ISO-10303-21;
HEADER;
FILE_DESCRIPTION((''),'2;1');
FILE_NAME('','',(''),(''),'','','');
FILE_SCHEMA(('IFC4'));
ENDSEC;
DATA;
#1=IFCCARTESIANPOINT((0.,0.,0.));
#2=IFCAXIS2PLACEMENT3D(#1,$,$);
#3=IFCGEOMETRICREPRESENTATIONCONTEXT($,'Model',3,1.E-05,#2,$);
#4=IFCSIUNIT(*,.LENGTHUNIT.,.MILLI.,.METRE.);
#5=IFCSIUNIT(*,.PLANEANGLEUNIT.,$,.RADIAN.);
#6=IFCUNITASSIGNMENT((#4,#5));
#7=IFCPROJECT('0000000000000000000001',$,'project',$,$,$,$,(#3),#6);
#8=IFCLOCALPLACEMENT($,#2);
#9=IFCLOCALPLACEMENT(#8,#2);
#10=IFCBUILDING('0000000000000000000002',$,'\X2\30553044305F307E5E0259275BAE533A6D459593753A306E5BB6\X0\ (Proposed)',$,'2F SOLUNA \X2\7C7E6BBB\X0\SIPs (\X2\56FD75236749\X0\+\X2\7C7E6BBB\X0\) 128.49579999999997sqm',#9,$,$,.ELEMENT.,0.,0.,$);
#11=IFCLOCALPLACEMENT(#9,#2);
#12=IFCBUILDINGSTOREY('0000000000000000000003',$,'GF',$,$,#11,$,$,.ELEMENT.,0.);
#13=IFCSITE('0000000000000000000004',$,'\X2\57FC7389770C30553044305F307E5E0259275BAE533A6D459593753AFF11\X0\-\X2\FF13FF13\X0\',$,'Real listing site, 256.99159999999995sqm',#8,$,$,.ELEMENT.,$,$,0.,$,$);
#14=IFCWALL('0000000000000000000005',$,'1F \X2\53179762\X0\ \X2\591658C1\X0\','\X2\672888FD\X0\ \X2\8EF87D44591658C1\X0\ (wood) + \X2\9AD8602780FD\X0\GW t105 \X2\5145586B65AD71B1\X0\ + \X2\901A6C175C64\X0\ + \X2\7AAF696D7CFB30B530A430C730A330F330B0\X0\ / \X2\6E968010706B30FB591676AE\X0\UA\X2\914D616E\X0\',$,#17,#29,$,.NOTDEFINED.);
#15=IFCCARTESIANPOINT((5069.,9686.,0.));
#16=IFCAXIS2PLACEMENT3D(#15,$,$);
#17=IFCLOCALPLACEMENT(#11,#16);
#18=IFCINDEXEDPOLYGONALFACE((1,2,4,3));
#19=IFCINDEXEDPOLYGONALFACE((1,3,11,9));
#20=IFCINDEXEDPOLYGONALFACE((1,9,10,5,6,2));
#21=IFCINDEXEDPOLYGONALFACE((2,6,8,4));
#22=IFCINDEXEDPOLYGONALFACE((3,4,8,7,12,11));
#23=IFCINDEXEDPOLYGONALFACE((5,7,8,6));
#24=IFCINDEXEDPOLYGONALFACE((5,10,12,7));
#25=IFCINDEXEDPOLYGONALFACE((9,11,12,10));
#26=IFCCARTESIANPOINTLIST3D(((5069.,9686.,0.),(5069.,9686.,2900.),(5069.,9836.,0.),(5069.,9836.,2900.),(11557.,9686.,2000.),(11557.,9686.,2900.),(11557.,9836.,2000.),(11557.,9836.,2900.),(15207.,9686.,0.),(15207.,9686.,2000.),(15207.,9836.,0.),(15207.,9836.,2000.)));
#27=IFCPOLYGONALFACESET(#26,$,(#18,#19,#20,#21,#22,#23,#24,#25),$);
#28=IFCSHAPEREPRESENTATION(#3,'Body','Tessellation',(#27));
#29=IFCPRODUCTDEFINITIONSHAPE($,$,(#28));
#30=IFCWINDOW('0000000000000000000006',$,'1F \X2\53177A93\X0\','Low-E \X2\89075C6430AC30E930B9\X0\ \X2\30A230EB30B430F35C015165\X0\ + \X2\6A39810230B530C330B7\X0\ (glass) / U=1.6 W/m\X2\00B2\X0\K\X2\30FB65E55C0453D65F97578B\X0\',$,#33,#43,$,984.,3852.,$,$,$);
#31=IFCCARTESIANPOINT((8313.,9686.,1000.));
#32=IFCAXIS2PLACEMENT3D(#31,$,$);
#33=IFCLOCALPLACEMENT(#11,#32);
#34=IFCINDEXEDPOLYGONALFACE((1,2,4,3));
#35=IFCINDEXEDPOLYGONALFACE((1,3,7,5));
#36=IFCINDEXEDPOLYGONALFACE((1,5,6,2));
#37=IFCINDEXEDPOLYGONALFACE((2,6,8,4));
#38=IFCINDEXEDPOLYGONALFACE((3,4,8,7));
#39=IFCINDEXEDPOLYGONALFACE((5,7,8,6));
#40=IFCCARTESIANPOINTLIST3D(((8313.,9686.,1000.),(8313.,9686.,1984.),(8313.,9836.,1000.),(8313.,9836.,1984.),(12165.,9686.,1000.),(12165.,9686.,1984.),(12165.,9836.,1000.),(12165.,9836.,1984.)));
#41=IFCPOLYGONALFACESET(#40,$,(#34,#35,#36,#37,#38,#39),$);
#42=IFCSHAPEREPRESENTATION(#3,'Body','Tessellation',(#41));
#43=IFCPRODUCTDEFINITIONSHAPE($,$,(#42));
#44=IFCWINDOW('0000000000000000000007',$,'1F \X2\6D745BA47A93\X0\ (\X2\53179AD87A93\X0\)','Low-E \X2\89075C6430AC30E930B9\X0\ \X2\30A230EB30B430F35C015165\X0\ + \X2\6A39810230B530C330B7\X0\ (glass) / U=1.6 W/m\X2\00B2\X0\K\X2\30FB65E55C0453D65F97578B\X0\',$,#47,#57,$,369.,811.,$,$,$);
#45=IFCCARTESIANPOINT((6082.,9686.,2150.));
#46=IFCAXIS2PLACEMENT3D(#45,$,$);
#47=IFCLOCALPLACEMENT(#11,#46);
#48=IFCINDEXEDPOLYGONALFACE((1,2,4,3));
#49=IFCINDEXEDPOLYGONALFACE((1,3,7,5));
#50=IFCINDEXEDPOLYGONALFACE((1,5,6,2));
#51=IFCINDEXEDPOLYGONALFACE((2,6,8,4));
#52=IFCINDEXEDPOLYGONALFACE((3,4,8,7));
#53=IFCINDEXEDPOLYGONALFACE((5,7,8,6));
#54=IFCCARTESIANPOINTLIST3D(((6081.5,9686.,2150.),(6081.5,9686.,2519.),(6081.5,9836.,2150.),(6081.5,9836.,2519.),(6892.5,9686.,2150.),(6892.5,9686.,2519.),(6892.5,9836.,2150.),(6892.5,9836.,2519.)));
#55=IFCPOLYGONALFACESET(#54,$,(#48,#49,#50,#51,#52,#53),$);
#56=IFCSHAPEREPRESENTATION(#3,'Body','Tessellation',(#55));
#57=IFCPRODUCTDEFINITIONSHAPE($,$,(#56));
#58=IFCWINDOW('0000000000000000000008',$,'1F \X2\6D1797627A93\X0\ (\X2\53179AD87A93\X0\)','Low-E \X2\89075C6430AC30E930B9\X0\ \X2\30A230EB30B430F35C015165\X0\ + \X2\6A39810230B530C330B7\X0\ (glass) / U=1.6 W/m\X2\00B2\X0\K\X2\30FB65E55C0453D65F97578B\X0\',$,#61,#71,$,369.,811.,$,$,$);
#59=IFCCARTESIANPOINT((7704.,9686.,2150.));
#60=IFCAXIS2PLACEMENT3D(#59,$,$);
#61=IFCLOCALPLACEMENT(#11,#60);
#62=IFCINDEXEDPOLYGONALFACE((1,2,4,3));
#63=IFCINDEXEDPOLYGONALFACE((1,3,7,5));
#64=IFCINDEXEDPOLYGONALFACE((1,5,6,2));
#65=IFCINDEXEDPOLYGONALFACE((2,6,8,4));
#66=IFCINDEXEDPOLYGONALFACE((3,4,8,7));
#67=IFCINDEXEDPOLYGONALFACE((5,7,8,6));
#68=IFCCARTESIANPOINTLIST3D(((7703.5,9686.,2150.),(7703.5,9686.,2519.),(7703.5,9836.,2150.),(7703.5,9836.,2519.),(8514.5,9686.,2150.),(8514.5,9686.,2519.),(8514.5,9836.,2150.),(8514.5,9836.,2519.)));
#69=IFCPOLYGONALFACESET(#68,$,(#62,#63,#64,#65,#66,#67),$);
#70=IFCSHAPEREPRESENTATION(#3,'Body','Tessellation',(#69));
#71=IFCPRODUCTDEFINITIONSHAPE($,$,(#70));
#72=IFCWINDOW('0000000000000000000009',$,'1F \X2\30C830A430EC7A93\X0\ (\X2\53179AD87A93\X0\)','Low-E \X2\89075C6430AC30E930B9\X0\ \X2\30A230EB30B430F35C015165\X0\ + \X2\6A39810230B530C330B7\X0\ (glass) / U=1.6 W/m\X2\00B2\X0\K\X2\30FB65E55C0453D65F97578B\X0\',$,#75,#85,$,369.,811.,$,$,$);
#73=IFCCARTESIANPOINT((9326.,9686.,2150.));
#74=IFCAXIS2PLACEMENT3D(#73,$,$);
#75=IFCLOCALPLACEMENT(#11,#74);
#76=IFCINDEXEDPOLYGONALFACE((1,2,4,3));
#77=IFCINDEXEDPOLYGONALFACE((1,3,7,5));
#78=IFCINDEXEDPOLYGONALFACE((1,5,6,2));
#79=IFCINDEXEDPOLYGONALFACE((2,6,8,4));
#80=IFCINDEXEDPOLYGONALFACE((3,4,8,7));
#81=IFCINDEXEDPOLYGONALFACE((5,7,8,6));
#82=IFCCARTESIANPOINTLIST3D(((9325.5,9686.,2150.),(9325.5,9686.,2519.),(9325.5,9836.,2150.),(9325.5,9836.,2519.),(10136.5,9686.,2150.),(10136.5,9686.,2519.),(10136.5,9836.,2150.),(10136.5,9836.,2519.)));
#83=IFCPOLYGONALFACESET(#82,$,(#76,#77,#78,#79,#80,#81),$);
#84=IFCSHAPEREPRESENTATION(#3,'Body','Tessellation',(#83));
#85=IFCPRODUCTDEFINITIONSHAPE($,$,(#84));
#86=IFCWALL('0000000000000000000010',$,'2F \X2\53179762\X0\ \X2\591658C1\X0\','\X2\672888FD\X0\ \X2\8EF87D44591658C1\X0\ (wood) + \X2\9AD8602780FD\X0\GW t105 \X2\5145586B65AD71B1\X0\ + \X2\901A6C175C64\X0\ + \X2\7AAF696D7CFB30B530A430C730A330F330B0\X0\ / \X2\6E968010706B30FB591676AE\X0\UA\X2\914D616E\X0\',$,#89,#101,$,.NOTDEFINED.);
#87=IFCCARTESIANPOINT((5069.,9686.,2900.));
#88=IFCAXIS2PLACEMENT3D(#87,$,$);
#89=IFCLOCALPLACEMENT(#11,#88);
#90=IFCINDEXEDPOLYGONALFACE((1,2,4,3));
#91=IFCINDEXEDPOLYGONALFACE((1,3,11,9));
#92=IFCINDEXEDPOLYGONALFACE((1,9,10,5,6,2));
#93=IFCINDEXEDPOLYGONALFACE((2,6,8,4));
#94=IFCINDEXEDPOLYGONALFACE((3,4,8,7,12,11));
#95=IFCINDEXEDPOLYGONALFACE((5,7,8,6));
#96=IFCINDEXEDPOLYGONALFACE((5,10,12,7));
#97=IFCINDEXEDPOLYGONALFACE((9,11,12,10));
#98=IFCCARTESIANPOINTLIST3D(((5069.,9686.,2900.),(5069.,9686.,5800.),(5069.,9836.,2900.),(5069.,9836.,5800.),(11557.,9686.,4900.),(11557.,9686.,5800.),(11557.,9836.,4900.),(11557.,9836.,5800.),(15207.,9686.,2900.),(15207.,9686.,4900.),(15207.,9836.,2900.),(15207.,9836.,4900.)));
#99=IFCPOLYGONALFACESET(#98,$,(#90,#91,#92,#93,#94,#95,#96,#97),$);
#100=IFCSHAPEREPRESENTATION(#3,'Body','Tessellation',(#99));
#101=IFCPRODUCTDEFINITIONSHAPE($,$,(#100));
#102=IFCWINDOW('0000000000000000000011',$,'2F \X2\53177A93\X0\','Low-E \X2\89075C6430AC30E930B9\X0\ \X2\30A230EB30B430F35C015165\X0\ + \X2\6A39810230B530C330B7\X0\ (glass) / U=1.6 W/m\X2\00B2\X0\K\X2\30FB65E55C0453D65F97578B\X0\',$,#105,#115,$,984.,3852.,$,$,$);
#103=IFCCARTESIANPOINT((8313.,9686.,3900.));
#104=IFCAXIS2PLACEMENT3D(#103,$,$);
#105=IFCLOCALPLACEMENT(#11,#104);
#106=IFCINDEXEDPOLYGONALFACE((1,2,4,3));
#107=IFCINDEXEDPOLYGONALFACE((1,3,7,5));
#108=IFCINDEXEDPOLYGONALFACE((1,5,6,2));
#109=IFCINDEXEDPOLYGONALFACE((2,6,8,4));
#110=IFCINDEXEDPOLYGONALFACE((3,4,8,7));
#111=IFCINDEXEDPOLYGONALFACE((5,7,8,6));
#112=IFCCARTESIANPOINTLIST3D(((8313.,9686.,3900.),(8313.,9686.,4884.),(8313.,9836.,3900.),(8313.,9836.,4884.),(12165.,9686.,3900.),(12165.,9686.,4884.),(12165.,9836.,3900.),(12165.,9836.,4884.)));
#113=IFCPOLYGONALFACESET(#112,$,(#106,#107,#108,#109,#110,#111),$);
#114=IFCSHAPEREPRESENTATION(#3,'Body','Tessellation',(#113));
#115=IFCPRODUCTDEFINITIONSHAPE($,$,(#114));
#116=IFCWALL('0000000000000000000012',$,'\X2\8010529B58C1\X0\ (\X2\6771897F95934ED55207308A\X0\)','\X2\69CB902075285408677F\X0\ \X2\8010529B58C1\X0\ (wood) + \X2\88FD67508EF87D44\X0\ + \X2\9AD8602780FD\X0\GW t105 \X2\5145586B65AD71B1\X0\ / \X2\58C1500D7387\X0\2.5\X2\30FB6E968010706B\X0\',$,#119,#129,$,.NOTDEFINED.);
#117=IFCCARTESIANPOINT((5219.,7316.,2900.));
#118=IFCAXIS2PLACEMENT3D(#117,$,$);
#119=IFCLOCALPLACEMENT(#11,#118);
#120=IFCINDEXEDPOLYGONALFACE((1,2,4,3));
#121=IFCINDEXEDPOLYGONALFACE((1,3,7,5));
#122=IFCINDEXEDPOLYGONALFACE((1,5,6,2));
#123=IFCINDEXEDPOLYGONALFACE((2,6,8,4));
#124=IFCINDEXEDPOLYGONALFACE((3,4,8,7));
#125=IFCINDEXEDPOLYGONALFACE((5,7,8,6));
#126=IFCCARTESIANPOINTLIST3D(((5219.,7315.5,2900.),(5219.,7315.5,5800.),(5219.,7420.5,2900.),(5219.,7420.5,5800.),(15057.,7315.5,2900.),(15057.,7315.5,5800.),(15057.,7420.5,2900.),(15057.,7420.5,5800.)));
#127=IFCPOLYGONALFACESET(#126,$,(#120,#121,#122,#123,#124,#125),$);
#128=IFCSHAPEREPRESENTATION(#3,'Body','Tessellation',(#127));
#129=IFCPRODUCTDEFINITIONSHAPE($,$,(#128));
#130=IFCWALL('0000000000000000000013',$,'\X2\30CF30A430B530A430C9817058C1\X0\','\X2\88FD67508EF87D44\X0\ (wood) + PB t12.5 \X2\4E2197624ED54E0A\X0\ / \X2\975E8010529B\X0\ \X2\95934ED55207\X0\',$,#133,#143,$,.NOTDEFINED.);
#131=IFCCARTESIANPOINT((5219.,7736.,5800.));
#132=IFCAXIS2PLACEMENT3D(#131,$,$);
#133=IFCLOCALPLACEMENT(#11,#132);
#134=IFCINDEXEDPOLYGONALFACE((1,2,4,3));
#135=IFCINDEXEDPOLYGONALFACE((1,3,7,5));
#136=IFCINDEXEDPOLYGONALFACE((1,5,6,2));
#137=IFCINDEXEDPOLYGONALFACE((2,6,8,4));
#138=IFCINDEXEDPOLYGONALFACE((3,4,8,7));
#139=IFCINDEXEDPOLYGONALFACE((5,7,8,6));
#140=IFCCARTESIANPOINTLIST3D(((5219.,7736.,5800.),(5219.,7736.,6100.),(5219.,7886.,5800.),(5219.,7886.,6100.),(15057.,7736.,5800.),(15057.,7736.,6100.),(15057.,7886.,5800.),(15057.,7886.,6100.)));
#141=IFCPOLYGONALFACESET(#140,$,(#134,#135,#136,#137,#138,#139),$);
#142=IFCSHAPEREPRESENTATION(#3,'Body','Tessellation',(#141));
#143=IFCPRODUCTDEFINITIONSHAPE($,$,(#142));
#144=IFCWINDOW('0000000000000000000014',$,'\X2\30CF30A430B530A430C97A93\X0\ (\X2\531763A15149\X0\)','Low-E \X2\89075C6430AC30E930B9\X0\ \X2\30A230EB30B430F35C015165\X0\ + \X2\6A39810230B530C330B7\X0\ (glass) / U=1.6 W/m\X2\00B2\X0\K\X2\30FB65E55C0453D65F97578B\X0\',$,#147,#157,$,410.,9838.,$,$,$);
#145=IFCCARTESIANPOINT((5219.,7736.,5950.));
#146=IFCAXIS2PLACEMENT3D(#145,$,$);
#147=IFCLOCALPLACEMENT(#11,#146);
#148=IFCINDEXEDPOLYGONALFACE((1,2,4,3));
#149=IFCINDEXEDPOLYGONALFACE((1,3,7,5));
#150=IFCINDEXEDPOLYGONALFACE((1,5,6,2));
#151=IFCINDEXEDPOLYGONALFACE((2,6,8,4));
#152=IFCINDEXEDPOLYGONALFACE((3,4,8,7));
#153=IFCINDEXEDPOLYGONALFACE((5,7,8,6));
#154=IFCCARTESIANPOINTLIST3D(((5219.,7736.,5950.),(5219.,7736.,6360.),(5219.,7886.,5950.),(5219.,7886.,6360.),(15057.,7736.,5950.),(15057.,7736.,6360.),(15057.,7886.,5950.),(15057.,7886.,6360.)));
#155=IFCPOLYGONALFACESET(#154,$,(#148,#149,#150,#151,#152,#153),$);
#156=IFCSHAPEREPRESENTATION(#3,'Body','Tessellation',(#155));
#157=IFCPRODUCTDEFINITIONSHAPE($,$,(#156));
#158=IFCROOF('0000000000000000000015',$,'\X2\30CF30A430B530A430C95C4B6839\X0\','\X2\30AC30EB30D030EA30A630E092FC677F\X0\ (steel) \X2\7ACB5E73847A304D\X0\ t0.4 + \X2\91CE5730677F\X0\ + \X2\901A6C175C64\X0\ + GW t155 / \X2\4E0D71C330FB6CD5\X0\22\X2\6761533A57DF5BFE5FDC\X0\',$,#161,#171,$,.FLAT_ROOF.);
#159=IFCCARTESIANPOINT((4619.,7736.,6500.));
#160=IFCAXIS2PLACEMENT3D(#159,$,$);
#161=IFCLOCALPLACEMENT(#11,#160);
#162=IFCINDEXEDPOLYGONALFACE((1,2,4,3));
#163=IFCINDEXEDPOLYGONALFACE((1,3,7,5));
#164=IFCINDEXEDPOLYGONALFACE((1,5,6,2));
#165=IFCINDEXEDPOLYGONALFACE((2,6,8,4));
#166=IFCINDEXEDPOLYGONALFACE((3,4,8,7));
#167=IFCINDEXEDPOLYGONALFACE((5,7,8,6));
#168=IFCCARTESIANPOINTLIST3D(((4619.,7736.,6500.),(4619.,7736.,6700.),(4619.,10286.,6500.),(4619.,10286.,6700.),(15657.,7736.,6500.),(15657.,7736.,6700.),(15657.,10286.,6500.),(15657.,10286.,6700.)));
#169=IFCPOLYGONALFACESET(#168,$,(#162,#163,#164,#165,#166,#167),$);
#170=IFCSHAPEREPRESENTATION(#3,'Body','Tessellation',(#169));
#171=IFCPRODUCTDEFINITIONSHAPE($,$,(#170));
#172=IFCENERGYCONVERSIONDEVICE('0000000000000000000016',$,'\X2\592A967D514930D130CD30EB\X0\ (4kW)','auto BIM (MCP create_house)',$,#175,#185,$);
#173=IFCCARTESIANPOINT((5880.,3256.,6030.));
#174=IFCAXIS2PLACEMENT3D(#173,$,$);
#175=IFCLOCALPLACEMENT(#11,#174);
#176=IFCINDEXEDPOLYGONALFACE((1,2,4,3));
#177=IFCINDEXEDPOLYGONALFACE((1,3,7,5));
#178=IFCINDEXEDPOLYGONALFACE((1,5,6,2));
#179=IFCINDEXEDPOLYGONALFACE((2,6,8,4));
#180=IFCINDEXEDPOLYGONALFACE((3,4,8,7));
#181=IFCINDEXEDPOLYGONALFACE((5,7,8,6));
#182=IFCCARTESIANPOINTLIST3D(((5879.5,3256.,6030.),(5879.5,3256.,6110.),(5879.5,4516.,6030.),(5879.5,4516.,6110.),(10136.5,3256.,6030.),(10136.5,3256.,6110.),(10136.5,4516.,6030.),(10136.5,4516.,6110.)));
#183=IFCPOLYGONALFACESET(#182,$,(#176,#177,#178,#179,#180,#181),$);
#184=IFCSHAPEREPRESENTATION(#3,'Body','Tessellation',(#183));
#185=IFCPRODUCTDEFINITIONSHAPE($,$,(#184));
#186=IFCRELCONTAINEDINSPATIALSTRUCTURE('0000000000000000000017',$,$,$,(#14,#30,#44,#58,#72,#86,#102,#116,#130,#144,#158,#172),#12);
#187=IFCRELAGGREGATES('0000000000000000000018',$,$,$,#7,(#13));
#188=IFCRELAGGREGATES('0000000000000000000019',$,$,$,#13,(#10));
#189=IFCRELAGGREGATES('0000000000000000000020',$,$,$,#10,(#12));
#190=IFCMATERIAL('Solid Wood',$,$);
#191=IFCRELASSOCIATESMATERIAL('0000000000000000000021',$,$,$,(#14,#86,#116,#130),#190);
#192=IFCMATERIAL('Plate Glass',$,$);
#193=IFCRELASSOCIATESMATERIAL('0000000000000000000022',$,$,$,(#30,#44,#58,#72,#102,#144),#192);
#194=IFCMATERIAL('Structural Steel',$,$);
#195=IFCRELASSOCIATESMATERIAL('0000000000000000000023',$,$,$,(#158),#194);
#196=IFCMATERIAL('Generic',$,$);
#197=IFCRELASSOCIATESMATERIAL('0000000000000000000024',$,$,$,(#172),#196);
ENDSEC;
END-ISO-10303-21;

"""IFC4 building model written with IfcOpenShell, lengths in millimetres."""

from ifc_helpers import new_model, si_unit, frame, frame_2d, origin, place, context, project, spatial, rectangle, extrude, material, element, fill, save


model = new_model("IFC4")

# Units and contexts
model_context = context("Model", 3, precision=1e-05, world=origin())
ifc_project = project(units=[si_unit("LENGTHUNIT", "METRE", prefix="MILLI"), si_unit("PLANEANGLEUNIT", "RADIAN")], contexts=[model_context])

# Site, building, storey
site_placement = place(None, origin())
site = spatial("IfcSite", under=ifc_project, at=site_placement, Name="埼玉県さいたま市大宮区浅間町１-３３", ObjectType="Real listing site, 256.99159999999995sqm", CompositionType="ELEMENT", RefElevation=0.0)
building_placement = place(site_placement, origin())
building = spatial("IfcBuilding", under=site, at=building_placement, Name="さいたま市大宮区浅間町の家 (Proposed)", ObjectType="2F SOLUNA 籾殻SIPs (国産杉+籾殻) 128.49579999999997sqm", CompositionType="ELEMENT", ElevationOfRefHeight=0.0, ElevationOfTerrain=0.0)
storey_placement = place(building_placement, origin())
storey = spatial("IfcBuildingStorey", under=building, at=storey_placement, Name="GF", CompositionType="ELEMENT", Elevation=0.0)

# Wall, openings, windows
ifc_material_1 = material(Name="Solid Wood")
wall_1_placement = place(storey_placement, frame((5069.0, 9686.0, 0.0)))
wall_1 = element("IfcWall", 1, at=wall_1_placement, inside=storey, material=ifc_material_1, Name="1F 北面 外壁", Description="木製 軸組外壁 (wood) + 高性能GW t105 充填断熱 + 通気層 + 窯業系サイディング / 準耐火・外皮UA配慮", PredefinedType="NOTDEFINED", context=model_context, shape_type="SweptSolid", body=[
    extrude(rectangle(XDim=10138.0, YDim=150.0, at=frame_2d((5069.0, 75.0))), frame((5069.0, 9686.0, 0.0)), (0.0, 0.0, 1.0), 2900.0),
])
opening_1_placement = place(storey_placement, frame((8313.0, 9686.0, 1000.0)))
opening_1 = element("IfcOpeningElement", 2, at=opening_1_placement, cuts=wall_1, PredefinedType="NOTDEFINED", context=model_context, shape_type="SweptSolid", body=[
    extrude(rectangle(XDim=3852.0, YDim=150.0, at=frame_2d((1926.0, 75.0))), frame((8313.0, 9686.0, 1000.0)), (0.0, 0.0, 1.0), 984.0),
])
opening_2_placement = place(storey_placement, frame((6082.0, 9686.0, 2150.0)))
opening_2 = element("IfcOpeningElement", 3, at=opening_2_placement, cuts=wall_1, PredefinedType="NOTDEFINED", context=model_context, shape_type="SweptSolid", body=[
    extrude(rectangle(XDim=811.0, YDim=150.0, at=frame_2d((405.0, 75.0))), frame((6082.0, 9686.0, 2150.0)), (0.0, 0.0, 1.0), 369.0),
])
opening_3_placement = place(storey_placement, frame((7704.0, 9686.0, 2150.0)))
opening_3 = element("IfcOpeningElement", 4, at=opening_3_placement, cuts=wall_1, PredefinedType="NOTDEFINED", context=model_context, shape_type="SweptSolid", body=[
    extrude(rectangle(XDim=811.0, YDim=150.0, at=frame_2d((405.0, 75.0))), frame((7704.0, 9686.0, 2150.0)), (0.0, 0.0, 1.0), 369.0),
])
opening_4_placement = place(storey_placement, frame((9326.0, 9686.0, 2150.0)))
opening_4 = element("IfcOpeningElement", 5, at=opening_4_placement, cuts=wall_1, PredefinedType="NOTDEFINED", context=model_context, shape_type="SweptSolid", body=[
    extrude(rectangle(XDim=811.0, YDim=150.0, at=frame_2d((405.0, 75.0))), frame((9326.0, 9686.0, 2150.0)), (0.0, 0.0, 1.0), 369.0),
])
ifc_material_2 = material(Name="Plate Glass")
window_1_placement = place(storey_placement, frame((8313.0, 9686.0, 1000.0)))
window_1 = element("IfcWindow", 6, at=window_1_placement, inside=storey, material=ifc_material_2, Name="1F 北窓", Description="Low-E 複層ガラス アルゴン封入 + 樹脂サッシ (glass) / U=1.6 W/m²K・日射取得型", OverallHeight=984.0, OverallWidth=3852.0, context=model_context, shape_type="SweptSolid", body=[
    extrude(rectangle(XDim=3852.0, YDim=150.0, at=frame_2d((1926.0, 75.0))), frame((8313.0, 9686.0, 1000.0)), (0.0, 0.0, 1.0), 984.0),
])
fill(opening_1, window_1)
window_2_placement = place(storey_placement, frame((6082.0, 9686.0, 2150.0)))
window_2 = element("IfcWindow", 7, at=window_2_placement, inside=storey, material=ifc_material_2, Name="1F 浴室窓 (北高窓)", Description="Low-E 複層ガラス アルゴン封入 + 樹脂サッシ (glass) / U=1.6 W/m²K・日射取得型", OverallHeight=369.0, OverallWidth=811.0, context=model_context, shape_type="SweptSolid", body=[
    extrude(rectangle(XDim=811.0, YDim=150.0, at=frame_2d((405.0, 75.0))), frame((6082.0, 9686.0, 2150.0)), (0.0, 0.0, 1.0), 369.0),
])
fill(opening_2, window_2)
window_3_placement = place(storey_placement, frame((7704.0, 9686.0, 2150.0)))
window_3 = element("IfcWindow", 8, at=window_3_placement, inside=storey, material=ifc_material_2, Name="1F 洗面窓 (北高窓)", Description="Low-E 複層ガラス アルゴン封入 + 樹脂サッシ (glass) / U=1.6 W/m²K・日射取得型", OverallHeight=369.0, OverallWidth=811.0, context=model_context, shape_type="SweptSolid", body=[
    extrude(rectangle(XDim=811.0, YDim=150.0, at=frame_2d((405.0, 75.0))), frame((7704.0, 9686.0, 2150.0)), (0.0, 0.0, 1.0), 369.0),
])
fill(opening_3, window_3)
window_4_placement = place(storey_placement, frame((9326.0, 9686.0, 2150.0)))
window_4 = element("IfcWindow", 9, at=window_4_placement, inside=storey, material=ifc_material_2, Name="1F トイレ窓 (北高窓)", Description="Low-E 複層ガラス アルゴン封入 + 樹脂サッシ (glass) / U=1.6 W/m²K・日射取得型", OverallHeight=369.0, OverallWidth=811.0, context=model_context, shape_type="SweptSolid", body=[
    extrude(rectangle(XDim=811.0, YDim=150.0, at=frame_2d((405.0, 75.0))), frame((9326.0, 9686.0, 2150.0)), (0.0, 0.0, 1.0), 369.0),
])
fill(opening_4, window_4)

# Wall, opening, window
wall_2_placement = place(storey_placement, frame((5069.0, 9686.0, 2900.0)))
wall_2 = element("IfcWall", 10, at=wall_2_placement, inside=storey, material=ifc_material_1, Name="2F 北面 外壁", Description="木製 軸組外壁 (wood) + 高性能GW t105 充填断熱 + 通気層 + 窯業系サイディング / 準耐火・外皮UA配慮", PredefinedType="NOTDEFINED", context=model_context, shape_type="SweptSolid", body=[
    extrude(rectangle(XDim=10138.0, YDim=150.0, at=frame_2d((5069.0, 75.0))), frame((5069.0, 9686.0, 2900.0)), (0.0, 0.0, 1.0), 2900.0),
])
opening_5_placement = place(storey_placement, frame((8313.0, 9686.0, 3900.0)))
opening_5 = element("IfcOpeningElement", 11, at=opening_5_placement, cuts=wall_2, PredefinedType="NOTDEFINED", context=model_context, shape_type="SweptSolid", body=[
    extrude(rectangle(XDim=3852.0, YDim=150.0, at=frame_2d((1926.0, 75.0))), frame((8313.0, 9686.0, 3900.0)), (0.0, 0.0, 1.0), 984.0),
])
window_5_placement = place(storey_placement, frame((8313.0, 9686.0, 3900.0)))
window_5 = element("IfcWindow", 12, at=window_5_placement, inside=storey, material=ifc_material_2, Name="2F 北窓", Description="Low-E 複層ガラス アルゴン封入 + 樹脂サッシ (glass) / U=1.6 W/m²K・日射取得型", OverallHeight=984.0, OverallWidth=3852.0, context=model_context, shape_type="SweptSolid", body=[
    extrude(rectangle(XDim=3852.0, YDim=150.0, at=frame_2d((1926.0, 75.0))), frame((8313.0, 9686.0, 3900.0)), (0.0, 0.0, 1.0), 984.0),
])
fill(opening_5, window_5)

# Wall
wall_3_placement = place(storey_placement, frame((5219.0, 7316.0, 2900.0)))
element("IfcWall", 13, at=wall_3_placement, inside=storey, material=ifc_material_1, Name="耐力壁 (東西間仕切り)", Description="構造用合板 耐力壁 (wood) + 製材軸組 + 高性能GW t105 充填断熱 / 壁倍率2.5・準耐火", PredefinedType="NOTDEFINED", context=model_context, shape_type="SweptSolid", body=[
    extrude(rectangle(XDim=9838.0, YDim=105.0, at=frame_2d((4919.0, 52.0))), frame((5219.0, 7316.0, 2900.0)), (0.0, 0.0, 1.0), 2900.0),
])

# Wall, opening, window
wall_4_placement = place(storey_placement, frame((5219.0, 7736.0, 5800.0)))
wall_4 = element("IfcWall", 14, at=wall_4_placement, inside=storey, material=ifc_material_1, Name="ハイサイド腰壁", Description="製材軸組 (wood) + PB t12.5 両面仕上 / 非耐力 間仕切", PredefinedType="NOTDEFINED", context=model_context, shape_type="SweptSolid", body=[
    extrude(rectangle(XDim=9838.0, YDim=150.0, at=frame_2d((4919.0, 75.0))), frame((5219.0, 7736.0, 5800.0)), (0.0, 0.0, 1.0), 700.0),
])
opening_6_placement = place(storey_placement, frame((5219.0, 7736.0, 5950.0)))
opening_6 = element("IfcOpeningElement", 15, at=opening_6_placement, cuts=wall_4, PredefinedType="NOTDEFINED", context=model_context, shape_type="SweptSolid", body=[
    extrude(rectangle(XDim=9838.0, YDim=150.0, at=frame_2d((4919.0, 75.0))), frame((5219.0, 7736.0, 5950.0)), (0.0, 0.0, 1.0), 410.0),
])
window_6_placement = place(storey_placement, frame((5219.0, 7736.0, 5950.0)))
window_6 = element("IfcWindow", 16, at=window_6_placement, inside=storey, material=ifc_material_2, Name="ハイサイド窓 (北採光)", Description="Low-E 複層ガラス アルゴン封入 + 樹脂サッシ (glass) / U=1.6 W/m²K・日射取得型", OverallHeight=410.0, OverallWidth=9838.0, context=model_context, shape_type="SweptSolid", body=[
    extrude(rectangle(XDim=9838.0, YDim=150.0, at=frame_2d((4919.0, 75.0))), frame((5219.0, 7736.0, 5950.0)), (0.0, 0.0, 1.0), 410.0),
])
fill(opening_6, window_6)

# Roof
ifc_material_3 = material(Name="Structural Steel")
roof_placement = place(storey_placement, frame((4619.0, 7736.0, 6500.0)))
element("IfcRoof", 17, at=roof_placement, inside=storey, material=ifc_material_3, Name="ハイサイド屋根", Description="ガルバリウム鋼板 (steel) 立平葺き t0.4 + 野地板 + 通気層 + GW t155 / 不燃・法22条区域対応", PredefinedType="FLAT_ROOF", context=model_context, shape_type="SweptSolid", body=[
    extrude(rectangle(XDim=11038.0, YDim=2550.0, at=frame_2d((5519.0, 1275.0))), frame((4619.0, 7736.0, 6500.0)), (0.0, 0.0, 1.0), 200.0),
])

# Energy conversion device
ifc_material_4 = material(Name="Generic")
energy_conversion_device_placement = place(storey_placement, frame((5880.0, 3256.0, 6030.0)))
element("IfcEnergyConversionDevice", 18, at=energy_conversion_device_placement, inside=storey, material=ifc_material_4, Name="太陽光パネル (4kW)", Description="auto BIM (MCP create_house)", context=model_context, shape_type="SweptSolid", body=[
    extrude(rectangle(XDim=4257.0, YDim=1260.0, at=frame_2d((2128.0, 630.0))), frame((5880.0, 3256.0, 6030.0)), (0.0, 0.0, 1.0), 80.0),
])

save(model, "model.ifc")
